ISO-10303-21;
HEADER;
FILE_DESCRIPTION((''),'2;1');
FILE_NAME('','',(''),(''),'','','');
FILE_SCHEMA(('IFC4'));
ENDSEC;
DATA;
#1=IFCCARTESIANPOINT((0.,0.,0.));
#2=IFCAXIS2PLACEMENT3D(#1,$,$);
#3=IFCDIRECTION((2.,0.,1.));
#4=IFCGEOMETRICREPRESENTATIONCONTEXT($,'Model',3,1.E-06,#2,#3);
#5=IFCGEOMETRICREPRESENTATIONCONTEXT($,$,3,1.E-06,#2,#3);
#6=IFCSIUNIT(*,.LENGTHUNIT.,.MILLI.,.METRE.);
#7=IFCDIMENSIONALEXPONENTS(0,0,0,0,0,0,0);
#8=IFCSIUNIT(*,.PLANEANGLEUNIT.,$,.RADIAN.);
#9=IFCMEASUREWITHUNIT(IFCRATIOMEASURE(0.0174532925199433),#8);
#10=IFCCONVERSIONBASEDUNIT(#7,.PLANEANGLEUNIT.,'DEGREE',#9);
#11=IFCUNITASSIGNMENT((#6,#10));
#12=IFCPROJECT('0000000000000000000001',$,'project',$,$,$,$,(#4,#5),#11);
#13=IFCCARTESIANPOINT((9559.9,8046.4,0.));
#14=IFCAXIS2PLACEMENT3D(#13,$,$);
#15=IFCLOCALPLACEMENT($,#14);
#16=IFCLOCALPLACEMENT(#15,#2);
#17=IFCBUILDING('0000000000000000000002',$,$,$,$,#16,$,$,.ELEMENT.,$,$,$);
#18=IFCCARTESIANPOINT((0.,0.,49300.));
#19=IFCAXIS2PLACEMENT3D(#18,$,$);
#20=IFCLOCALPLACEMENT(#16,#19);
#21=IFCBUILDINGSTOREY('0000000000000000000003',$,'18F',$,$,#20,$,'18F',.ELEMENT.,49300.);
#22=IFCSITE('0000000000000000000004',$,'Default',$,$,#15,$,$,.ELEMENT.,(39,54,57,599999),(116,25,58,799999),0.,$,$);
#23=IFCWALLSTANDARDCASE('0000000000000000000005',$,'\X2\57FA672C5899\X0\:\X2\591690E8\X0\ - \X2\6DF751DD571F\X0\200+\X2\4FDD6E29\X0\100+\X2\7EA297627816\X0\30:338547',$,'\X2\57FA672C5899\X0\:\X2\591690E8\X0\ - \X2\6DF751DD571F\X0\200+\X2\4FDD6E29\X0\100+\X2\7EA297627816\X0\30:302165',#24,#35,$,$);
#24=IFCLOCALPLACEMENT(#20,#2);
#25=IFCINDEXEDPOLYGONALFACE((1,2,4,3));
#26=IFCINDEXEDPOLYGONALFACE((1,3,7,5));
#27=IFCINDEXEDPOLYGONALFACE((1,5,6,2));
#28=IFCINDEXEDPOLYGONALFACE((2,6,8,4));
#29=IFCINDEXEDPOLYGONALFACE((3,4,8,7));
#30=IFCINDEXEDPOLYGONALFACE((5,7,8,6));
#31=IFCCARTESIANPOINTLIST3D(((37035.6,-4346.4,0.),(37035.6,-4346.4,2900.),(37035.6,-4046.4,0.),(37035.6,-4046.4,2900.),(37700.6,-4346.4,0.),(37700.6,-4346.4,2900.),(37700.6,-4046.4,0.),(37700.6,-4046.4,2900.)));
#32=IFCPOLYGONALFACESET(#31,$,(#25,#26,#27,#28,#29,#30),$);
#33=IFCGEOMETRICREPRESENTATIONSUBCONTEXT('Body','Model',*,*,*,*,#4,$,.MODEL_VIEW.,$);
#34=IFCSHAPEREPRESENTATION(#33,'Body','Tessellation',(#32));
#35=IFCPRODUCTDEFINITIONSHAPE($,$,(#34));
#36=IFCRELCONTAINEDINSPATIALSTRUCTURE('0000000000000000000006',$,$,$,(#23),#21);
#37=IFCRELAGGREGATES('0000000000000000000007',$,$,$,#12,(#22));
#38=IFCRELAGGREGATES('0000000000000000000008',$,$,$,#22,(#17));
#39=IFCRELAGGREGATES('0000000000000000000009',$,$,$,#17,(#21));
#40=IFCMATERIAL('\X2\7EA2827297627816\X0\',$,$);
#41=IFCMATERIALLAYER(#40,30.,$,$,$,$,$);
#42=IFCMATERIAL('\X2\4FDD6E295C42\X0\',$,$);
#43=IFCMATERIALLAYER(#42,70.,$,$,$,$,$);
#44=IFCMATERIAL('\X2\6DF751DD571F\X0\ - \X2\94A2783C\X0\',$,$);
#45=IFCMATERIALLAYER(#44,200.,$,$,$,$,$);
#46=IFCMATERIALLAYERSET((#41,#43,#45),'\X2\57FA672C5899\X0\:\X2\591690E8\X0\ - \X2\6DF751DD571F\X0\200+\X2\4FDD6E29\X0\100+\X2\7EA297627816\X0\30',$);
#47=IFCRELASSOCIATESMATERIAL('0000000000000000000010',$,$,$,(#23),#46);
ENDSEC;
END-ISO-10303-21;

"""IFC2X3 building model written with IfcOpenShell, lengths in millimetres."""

from ifc_helpers import new_model, entity, si_unit, converted_unit, direction, frame, frame_2d, origin, place, context, subcontext, project, spatial, rectangle, extrude, material, layer, layer_set, layer_usage, element, save


model = new_model("IFC2X3")

# Units and contexts
model_context = context("Model", 3, precision=1e-06, world=origin(), true_north=direction((2.0, 0.0, 1.0)))
context_of_model = context(None, 3, precision=1e-06, world=origin(), true_north=direction((2.0, 0.0, 1.0)))
body_context = subcontext(model_context, "Body", "Model", "MODEL_VIEW")
ifc_project = project(units=[si_unit("LENGTHUNIT", "METRE", prefix="MILLI"), converted_unit("PLANEANGLEUNIT", "DEGREE", entity("IfcRatioMeasure", 0.0174532925199433), si_unit("PLANEANGLEUNIT", "RADIAN"), dimensions=[0, 0, 0, 0, 0, 0, 0])], contexts=[model_context, context_of_model])

# Site, building, storey
site_placement = place(None, frame((9559.9, 8046.4, 0.0)))
site = spatial("IfcSite", under=ifc_project, at=site_placement, Name="Default", CompositionType="ELEMENT", RefLatitude=(39, 54, 57, 599999), RefLongitude=(116, 25, 58, 799999), RefElevation=0.0)
building_placement = place(site_placement, origin())
building = spatial("IfcBuilding", under=site, at=building_placement, CompositionType="ELEMENT")
storey_placement = place(building_placement, frame((0.0, 0.0, 49300.0)))
storey = spatial("IfcBuildingStorey", under=building, at=storey_placement, Name="18F", LongName="18F", CompositionType="ELEMENT", Elevation=49300.0)

# Shared definitions
ifc_material_1 = material(Name="保温层")
ifc_material_2 = material(Name="混凝土 - 钢砼")

# Shared definitions
ifc_material_3 = material(Name="红色面砖")
ifc_layer_1 = layer(ifc_material_3, 30.0)
ifc_layer_2 = layer(ifc_material_1, 70.0)
ifc_layer_3 = layer(ifc_material_2, 200.0)
ifc_layer_set_1 = layer_set([ifc_layer_1, ifc_layer_2, ifc_layer_3], Name="基本墙:外部 - 混凝土200+保温100+红面砖30")

# Wall
ifc_layer_usage_1 = layer_usage(ifc_layer_set_1, "AXIS2", "NEGATIVE", 150.0)
wall_1_placement = place(storey_placement, frame((37700.6, -4196.4, 0.0), z_axis=(0.0, 0.0, 1.0), x_axis=(-1.0, 0.0, 0.0)))
element("IfcWallStandardCase", 1, at=wall_1_placement, inside=storey, material=ifc_layer_usage_1, Name="基本墙:外部 - 混凝土200+保温100+红面砖30:338547", ObjectType="基本墙:外部 - 混凝土200+保温100+红面砖30:302165", context=body_context, shape_type="SweptSolid", body=[
    extrude(rectangle(XDim=665.0, YDim=300.0, at=frame_2d((332.5, 0.0), x_axis=(-1.0, 0.0))), origin(), (0.0, 0.0, 1.0), 2900.0),
])

save(model, "model.ifc")
